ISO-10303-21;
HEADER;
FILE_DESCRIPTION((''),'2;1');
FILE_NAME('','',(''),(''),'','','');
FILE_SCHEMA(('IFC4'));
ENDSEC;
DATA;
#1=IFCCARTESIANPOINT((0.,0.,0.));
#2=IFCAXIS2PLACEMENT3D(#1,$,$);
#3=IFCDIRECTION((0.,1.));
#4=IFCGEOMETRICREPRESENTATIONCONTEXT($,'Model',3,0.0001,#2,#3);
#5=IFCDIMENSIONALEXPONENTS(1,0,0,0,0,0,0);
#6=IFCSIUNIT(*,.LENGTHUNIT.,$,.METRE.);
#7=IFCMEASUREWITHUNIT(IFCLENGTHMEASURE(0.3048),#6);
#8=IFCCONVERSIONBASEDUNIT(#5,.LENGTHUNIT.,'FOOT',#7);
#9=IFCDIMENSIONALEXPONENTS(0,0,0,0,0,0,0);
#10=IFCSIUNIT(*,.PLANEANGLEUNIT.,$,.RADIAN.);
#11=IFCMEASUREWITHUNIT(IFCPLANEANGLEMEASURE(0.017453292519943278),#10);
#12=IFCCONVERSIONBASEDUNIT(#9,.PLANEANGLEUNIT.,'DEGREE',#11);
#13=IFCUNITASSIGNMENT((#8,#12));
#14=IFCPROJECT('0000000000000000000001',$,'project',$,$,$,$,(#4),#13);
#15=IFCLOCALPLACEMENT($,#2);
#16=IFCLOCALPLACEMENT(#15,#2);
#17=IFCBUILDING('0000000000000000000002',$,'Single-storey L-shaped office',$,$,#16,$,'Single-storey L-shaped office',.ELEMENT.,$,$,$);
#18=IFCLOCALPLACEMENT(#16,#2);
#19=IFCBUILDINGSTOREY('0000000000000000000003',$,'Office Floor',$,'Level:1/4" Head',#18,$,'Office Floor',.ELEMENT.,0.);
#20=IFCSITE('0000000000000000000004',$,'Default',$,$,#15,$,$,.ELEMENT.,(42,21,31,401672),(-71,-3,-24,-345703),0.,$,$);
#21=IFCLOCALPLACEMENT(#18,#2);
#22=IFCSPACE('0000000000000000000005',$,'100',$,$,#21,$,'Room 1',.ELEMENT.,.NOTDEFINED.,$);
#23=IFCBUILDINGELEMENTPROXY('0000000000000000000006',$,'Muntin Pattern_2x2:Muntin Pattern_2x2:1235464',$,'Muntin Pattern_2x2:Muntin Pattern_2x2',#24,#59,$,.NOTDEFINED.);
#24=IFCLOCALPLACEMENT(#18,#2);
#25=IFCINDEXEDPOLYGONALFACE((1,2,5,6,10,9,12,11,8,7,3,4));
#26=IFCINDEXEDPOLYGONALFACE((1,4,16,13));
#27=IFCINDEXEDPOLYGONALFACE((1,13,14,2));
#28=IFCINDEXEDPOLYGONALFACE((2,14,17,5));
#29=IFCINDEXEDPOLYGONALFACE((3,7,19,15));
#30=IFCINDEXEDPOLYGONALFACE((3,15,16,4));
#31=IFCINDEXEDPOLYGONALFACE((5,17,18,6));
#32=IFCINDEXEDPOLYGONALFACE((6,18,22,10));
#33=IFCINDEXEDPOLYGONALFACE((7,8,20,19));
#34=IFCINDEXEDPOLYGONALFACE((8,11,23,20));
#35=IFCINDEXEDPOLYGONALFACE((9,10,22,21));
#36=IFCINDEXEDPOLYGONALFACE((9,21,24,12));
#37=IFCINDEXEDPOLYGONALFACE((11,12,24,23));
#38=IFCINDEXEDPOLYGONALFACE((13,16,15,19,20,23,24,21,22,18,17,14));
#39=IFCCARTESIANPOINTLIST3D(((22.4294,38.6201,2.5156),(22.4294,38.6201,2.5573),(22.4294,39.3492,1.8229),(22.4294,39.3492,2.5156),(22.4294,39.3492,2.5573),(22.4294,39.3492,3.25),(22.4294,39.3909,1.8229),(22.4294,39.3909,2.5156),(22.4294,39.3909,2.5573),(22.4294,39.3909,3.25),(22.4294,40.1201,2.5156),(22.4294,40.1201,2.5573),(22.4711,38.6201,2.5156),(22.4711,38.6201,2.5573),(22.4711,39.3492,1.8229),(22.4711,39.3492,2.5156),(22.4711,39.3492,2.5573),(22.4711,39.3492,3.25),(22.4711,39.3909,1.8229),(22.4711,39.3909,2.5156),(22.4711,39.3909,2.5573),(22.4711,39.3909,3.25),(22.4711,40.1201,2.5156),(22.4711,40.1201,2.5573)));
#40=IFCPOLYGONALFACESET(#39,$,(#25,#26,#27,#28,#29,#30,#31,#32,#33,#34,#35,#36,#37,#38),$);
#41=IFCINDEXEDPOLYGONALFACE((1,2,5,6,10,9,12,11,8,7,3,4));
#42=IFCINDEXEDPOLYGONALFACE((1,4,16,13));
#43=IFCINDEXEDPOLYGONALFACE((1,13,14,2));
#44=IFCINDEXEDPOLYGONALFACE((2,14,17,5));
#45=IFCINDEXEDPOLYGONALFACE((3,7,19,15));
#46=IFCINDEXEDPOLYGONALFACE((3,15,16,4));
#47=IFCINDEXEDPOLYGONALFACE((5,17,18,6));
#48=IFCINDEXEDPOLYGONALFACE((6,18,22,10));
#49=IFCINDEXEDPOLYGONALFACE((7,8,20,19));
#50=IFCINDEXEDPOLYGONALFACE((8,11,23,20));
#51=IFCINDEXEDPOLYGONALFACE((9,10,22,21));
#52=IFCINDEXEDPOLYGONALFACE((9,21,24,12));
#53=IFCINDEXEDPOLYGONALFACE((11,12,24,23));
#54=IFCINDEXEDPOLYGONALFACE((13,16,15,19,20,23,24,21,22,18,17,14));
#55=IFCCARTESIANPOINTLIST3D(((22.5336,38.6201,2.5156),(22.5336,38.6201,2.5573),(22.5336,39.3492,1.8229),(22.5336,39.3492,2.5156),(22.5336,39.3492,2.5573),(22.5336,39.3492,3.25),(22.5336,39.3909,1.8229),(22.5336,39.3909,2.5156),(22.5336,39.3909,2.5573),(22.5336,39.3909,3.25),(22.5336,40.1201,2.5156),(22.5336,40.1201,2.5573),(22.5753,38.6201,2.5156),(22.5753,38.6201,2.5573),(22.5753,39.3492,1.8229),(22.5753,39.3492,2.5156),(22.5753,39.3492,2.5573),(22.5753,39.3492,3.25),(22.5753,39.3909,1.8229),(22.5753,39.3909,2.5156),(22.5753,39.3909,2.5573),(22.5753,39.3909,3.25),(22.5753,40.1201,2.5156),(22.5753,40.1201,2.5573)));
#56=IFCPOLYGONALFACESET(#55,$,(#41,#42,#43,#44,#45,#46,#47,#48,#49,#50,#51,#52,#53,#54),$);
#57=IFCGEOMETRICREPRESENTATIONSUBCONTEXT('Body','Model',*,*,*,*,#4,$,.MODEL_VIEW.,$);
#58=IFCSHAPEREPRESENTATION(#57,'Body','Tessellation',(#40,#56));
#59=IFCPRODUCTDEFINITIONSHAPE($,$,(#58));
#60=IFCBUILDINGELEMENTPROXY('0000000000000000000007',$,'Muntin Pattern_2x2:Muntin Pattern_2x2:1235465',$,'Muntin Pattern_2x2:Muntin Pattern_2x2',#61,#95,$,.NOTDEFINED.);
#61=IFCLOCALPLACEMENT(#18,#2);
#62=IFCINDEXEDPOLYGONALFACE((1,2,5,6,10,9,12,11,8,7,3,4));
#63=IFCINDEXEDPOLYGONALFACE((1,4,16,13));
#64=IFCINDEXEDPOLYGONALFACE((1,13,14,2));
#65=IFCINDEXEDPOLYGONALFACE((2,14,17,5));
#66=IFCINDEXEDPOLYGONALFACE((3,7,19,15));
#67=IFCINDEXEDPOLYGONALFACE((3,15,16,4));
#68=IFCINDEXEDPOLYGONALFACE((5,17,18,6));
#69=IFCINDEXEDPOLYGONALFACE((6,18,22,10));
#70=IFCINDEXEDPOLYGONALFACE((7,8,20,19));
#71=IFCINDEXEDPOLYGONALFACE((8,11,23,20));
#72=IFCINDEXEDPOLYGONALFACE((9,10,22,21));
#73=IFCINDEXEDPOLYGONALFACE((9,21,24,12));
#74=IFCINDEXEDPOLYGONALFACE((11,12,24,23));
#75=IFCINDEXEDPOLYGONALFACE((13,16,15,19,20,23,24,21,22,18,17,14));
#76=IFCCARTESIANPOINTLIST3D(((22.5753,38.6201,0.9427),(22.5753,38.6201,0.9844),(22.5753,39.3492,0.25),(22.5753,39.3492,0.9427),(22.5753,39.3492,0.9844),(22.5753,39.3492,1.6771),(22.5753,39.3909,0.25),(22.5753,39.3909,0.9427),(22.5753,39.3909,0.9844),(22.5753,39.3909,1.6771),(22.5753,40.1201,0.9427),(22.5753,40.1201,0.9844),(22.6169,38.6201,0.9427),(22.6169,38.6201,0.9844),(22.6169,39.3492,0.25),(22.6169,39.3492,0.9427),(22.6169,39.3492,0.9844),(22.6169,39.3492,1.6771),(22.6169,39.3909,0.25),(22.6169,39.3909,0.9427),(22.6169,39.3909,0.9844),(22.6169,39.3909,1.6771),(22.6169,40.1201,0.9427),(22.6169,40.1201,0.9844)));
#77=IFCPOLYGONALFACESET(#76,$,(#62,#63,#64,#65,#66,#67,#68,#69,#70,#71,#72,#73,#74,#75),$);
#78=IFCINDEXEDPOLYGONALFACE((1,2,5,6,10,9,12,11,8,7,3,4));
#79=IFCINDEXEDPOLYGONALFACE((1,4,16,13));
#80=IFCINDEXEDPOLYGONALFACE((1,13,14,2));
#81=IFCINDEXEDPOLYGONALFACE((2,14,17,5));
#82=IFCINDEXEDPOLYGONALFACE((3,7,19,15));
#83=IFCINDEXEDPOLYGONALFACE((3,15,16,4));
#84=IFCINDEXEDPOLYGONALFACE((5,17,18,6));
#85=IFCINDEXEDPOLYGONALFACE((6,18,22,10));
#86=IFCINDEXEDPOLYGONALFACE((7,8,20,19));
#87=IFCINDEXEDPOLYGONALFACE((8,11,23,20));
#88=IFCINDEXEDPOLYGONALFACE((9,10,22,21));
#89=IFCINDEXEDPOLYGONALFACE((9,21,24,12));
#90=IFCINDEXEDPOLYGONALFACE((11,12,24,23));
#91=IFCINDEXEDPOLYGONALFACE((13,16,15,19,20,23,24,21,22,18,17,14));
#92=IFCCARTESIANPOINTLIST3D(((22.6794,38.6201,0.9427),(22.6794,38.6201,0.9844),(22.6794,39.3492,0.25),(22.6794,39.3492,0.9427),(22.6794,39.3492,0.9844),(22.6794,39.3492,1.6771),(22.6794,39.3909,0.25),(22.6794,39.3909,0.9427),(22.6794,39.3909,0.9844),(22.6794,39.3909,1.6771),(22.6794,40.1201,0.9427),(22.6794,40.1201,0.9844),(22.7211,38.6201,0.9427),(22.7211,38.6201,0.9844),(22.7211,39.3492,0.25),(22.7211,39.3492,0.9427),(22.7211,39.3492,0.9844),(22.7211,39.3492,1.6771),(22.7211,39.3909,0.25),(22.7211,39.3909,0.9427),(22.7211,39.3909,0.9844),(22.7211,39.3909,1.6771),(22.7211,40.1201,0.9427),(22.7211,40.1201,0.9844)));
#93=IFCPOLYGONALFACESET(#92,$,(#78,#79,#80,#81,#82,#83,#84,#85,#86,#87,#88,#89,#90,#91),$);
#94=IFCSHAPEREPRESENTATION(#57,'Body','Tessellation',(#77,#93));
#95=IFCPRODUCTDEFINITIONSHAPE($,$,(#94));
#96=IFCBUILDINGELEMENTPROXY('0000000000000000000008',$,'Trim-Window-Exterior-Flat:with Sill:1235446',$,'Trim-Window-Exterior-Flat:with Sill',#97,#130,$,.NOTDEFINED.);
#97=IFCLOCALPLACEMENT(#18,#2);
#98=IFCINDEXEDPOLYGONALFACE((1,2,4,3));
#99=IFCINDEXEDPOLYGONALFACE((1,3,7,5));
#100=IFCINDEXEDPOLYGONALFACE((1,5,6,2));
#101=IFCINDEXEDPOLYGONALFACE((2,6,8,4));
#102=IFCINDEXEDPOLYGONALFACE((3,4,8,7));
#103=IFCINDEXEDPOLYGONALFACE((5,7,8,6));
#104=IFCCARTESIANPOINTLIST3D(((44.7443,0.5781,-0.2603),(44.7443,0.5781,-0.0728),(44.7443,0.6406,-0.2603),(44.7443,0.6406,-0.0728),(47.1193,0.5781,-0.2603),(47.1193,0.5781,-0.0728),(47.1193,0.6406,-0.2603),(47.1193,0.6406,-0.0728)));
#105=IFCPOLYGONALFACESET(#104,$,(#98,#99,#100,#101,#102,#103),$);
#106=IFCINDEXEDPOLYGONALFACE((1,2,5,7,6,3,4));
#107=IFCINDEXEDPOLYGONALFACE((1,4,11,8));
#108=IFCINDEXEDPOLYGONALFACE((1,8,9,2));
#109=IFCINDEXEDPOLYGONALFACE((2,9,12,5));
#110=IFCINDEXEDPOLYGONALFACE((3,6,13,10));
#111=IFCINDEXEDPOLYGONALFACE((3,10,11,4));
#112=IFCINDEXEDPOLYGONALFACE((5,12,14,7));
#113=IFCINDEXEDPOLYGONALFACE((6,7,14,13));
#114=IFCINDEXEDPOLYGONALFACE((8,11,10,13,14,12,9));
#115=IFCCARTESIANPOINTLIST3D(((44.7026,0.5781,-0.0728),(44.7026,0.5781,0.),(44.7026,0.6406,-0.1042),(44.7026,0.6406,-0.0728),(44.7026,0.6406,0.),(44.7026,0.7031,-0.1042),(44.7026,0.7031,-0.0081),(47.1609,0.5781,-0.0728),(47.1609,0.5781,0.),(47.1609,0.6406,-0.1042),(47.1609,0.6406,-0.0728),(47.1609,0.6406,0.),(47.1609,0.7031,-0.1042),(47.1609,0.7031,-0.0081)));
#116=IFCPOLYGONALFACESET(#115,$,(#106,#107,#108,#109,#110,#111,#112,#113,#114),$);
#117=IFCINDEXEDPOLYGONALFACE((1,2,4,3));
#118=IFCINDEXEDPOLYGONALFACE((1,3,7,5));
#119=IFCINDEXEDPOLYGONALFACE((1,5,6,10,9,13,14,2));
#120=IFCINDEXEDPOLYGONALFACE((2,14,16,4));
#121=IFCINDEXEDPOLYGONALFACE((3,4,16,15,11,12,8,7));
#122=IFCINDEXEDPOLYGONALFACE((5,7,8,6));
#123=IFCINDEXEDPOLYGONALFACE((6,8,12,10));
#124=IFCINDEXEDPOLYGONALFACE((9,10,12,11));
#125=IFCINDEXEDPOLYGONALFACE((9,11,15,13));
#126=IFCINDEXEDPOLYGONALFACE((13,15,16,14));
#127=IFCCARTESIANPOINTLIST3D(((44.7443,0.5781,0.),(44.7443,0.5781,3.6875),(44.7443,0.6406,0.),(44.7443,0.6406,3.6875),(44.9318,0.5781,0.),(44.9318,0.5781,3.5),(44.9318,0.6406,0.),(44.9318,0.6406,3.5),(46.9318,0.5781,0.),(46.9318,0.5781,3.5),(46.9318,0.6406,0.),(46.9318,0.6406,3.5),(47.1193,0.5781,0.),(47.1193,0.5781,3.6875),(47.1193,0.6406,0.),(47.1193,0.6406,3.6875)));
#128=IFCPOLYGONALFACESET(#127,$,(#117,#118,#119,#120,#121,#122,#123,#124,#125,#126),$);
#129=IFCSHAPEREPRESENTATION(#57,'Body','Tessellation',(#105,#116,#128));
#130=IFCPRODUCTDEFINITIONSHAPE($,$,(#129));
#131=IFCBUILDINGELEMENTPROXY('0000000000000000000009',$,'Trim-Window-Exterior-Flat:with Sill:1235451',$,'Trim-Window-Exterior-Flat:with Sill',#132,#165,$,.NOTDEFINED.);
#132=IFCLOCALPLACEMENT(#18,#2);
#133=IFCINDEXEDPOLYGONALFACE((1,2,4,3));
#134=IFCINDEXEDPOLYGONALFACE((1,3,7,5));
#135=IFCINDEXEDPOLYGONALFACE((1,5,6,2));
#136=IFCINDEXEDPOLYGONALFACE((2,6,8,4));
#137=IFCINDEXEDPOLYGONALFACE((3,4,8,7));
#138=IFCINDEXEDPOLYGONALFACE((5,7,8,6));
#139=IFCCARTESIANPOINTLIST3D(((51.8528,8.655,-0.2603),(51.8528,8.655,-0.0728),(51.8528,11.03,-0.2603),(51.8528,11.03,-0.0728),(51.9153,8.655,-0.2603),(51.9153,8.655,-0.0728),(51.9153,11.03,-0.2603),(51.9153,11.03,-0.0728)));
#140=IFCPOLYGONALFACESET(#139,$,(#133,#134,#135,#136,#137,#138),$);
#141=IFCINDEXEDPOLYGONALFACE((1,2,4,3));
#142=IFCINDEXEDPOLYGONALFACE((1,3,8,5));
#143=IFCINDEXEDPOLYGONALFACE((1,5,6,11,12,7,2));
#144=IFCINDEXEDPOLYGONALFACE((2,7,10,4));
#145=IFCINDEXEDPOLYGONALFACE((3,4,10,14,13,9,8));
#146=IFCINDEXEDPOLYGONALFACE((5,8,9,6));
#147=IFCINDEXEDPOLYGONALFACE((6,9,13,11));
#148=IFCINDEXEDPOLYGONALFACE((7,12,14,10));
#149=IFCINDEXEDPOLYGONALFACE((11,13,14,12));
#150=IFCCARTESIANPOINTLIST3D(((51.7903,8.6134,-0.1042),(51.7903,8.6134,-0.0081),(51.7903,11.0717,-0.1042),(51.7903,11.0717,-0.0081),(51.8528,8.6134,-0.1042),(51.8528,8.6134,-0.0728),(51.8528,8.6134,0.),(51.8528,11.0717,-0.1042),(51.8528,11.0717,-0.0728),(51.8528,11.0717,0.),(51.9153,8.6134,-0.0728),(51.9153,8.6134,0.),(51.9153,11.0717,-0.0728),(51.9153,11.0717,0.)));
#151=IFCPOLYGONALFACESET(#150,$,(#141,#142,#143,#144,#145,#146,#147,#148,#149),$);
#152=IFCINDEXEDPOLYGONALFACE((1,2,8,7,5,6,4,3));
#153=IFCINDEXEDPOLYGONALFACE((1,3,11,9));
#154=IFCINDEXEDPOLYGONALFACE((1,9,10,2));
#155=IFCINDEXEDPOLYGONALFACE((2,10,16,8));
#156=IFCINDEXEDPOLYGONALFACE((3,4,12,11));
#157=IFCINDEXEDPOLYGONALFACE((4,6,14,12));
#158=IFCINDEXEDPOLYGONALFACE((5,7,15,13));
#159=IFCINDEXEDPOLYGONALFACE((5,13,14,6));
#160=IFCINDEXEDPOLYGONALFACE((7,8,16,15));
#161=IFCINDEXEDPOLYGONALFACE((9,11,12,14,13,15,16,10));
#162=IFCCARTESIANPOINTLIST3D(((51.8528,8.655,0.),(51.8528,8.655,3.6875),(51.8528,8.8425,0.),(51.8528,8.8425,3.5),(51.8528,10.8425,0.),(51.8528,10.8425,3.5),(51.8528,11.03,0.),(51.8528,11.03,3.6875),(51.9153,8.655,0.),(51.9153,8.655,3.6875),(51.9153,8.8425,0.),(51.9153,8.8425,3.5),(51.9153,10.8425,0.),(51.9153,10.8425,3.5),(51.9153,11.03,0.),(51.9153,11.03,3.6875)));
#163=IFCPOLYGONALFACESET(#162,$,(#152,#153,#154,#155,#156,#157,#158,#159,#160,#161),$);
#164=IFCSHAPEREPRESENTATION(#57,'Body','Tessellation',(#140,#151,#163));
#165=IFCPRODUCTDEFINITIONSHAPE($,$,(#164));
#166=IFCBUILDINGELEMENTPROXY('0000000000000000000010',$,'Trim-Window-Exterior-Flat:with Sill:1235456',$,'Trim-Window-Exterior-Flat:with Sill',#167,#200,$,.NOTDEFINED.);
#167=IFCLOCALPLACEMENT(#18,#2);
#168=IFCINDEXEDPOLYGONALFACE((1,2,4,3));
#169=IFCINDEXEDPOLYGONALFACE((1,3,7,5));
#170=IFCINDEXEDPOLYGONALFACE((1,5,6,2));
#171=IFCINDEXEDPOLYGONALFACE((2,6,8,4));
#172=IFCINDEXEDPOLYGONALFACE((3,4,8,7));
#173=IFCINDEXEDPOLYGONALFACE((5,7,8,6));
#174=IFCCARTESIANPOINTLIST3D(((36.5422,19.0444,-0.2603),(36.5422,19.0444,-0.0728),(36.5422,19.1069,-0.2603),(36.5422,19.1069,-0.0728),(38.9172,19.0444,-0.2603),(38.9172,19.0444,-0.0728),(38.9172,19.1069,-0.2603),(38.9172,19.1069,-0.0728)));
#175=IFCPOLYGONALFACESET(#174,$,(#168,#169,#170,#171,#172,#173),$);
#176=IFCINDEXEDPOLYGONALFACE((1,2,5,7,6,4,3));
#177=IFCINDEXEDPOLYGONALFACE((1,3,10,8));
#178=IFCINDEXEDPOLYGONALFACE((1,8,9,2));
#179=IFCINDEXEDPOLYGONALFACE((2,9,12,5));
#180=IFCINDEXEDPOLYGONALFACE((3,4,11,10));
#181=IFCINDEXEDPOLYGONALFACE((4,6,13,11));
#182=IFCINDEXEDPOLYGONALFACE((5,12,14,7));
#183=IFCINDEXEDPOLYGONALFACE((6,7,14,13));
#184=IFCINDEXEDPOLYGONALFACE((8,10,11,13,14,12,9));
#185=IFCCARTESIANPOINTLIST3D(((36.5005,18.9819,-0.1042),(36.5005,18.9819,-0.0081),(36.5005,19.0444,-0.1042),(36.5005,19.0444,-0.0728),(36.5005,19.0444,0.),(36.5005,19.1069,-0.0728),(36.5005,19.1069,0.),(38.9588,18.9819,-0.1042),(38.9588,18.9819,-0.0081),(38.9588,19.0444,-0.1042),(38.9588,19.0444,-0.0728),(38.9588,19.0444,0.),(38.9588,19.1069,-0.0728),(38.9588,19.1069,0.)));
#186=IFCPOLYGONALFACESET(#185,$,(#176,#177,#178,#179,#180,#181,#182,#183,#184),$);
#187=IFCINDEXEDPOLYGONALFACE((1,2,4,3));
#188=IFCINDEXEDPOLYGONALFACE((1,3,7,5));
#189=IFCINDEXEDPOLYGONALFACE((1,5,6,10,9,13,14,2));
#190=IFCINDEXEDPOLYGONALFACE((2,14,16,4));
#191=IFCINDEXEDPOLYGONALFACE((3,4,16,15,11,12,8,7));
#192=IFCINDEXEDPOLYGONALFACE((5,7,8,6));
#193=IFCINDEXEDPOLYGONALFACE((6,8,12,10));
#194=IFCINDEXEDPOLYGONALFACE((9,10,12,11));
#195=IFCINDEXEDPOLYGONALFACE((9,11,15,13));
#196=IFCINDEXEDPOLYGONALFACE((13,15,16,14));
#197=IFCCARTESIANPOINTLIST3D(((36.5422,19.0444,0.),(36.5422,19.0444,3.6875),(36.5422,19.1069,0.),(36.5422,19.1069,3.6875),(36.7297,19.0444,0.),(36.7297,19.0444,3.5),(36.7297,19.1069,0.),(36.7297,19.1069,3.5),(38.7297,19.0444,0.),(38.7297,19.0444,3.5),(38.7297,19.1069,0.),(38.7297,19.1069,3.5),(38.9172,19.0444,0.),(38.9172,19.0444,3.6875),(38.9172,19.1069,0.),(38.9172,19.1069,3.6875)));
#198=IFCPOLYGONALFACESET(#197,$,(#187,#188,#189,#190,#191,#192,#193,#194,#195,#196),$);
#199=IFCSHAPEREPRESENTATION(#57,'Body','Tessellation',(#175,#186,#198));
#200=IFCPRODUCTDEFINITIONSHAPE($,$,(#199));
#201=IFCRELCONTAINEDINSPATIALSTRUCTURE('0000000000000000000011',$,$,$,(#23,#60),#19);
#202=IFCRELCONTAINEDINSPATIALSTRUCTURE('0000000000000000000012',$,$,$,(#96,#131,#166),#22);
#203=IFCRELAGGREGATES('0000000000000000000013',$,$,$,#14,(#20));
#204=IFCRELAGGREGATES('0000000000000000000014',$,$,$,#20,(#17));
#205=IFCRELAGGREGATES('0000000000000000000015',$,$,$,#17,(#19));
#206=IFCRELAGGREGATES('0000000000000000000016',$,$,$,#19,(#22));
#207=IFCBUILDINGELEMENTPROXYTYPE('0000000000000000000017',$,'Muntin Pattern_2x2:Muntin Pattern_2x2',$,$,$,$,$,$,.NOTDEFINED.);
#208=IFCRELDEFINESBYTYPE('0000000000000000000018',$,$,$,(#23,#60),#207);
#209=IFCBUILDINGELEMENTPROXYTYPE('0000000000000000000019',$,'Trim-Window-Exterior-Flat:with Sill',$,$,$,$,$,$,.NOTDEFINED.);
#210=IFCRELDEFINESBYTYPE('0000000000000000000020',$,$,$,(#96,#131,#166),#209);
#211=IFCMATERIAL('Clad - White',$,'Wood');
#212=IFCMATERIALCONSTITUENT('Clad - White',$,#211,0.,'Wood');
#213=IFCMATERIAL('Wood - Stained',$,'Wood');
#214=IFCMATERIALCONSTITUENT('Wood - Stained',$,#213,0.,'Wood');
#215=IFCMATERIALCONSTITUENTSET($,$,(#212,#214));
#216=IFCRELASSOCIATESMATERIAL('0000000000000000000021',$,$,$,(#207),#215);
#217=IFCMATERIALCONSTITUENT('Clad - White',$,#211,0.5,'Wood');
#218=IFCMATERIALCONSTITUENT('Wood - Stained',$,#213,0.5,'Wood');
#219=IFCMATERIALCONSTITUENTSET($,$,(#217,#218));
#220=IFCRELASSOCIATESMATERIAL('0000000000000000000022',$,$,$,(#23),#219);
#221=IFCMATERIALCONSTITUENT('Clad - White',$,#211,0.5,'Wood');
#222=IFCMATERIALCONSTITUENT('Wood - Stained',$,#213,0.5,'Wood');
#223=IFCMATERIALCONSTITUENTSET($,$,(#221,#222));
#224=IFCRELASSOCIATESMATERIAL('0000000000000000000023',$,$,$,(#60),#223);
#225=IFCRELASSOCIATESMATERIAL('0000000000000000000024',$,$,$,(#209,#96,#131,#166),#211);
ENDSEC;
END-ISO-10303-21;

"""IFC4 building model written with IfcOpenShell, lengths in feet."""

from ifc_helpers import new_model, entity, si_unit, converted_unit, direction, frame, origin, place, context, subcontext, project, spatial, indexed_curve, outline, extrude, source, transform, mapped, material, constituent, constituent_set, type_object, type_shapes, element, save


model = new_model("IFC4")

# Units and contexts
model_context = context("Model", 3, precision=0.0001, world=origin(), true_north=direction((0.0, 1.0)))
body_context = subcontext(model_context, "Body", "Model", "MODEL_VIEW")
ifc_project = project(units=[converted_unit("LENGTHUNIT", "FOOT", entity("IfcLengthMeasure", 0.3048), si_unit("LENGTHUNIT", "METRE"), dimensions=[1, 0, 0, 0, 0, 0, 0]), converted_unit("PLANEANGLEUNIT", "DEGREE", entity("IfcPlaneAngleMeasure", 0.017453292519943278), si_unit("PLANEANGLEUNIT", "RADIAN"), dimensions=[0, 0, 0, 0, 0, 0, 0])], contexts=[model_context])

# Site, building, storey
site_placement = place(None, origin())
site = spatial("IfcSite", under=ifc_project, at=site_placement, Name="Default", CompositionType="ELEMENT", RefLatitude=(42, 21, 31, 401672), RefLongitude=(-71, -3, -24, -345703), RefElevation=0.0)
building_placement = place(site_placement, origin())
building = spatial("IfcBuilding", under=site, at=building_placement, Name="Single-storey L-shaped office", LongName="Single-storey L-shaped office", CompositionType="ELEMENT")
storey_placement = place(building_placement, origin())
storey = spatial("IfcBuildingStorey", under=building, at=storey_placement, Name="Office Floor", ObjectType="Level:1/4\" Head", LongName="Office Floor", CompositionType="ELEMENT", Elevation=0.0)

# Shared definitions
ifc_material_1 = material(Name="Wood - Stained", Category="Wood")

# Building element proxies
ifc_material_2 = material(Name="Clad - White", Category="Wood")
ifc_constituent_1 = constituent(ifc_material_2, Name="Clad - White", Category="Wood", fraction=0.0)
ifc_constituent_2 = constituent(ifc_material_1, Name="Wood - Stained", Category="Wood", fraction=0.0)
ifc_constituent_set_1 = constituent_set(constituents=[ifc_constituent_1, ifc_constituent_2])
building_element_proxy_type_1 = type_object("IfcBuildingElementProxyType", Name="Muntin Pattern_2x2:Muntin Pattern_2x2", PredefinedType="NOTDEFINED", material=ifc_constituent_set_1)
shared_shape_1 = source(origin(), body_context, "Body", "SweptSolid", [
    extrude(outline(indexed_curve([(0.0208, -0.0208), (0.7135, -0.0208), (0.7135, 0.0208), (0.0208, 0.0208), (0.0208, 0.75), (-0.0208, 0.75), (-0.0208, 0.0208), (-0.7135, 0.0208), (-0.7135, -0.0208), (-0.0208, -0.0208), (-0.0208, -0.75), (0.0208, -0.75), (0.0208, -0.0208)], self_intersect=False)), frame((0.0, 0.0312, 0.7135), z_axis=(0.0, 1.0, 0.0), x_axis=(0.0, 0.0, 1.0)), (0.0, 0.0, 1.0), 0.0417),
    extrude(outline(indexed_curve([(0.0208, -0.0208), (0.7135, -0.0208), (0.7135, 0.0208), (0.0208, 0.0208), (0.0208, 0.75), (-0.0208, 0.75), (-0.0208, 0.0208), (-0.7135, 0.0208), (-0.7135, -0.0208), (-0.0208, -0.0208), (-0.0208, -0.75), (0.0208, -0.75), (0.0208, -0.0208)], self_intersect=False)), frame((0.0, -0.0729, 0.7135), z_axis=(0.0, 1.0, 0.0), x_axis=(0.0, 0.0, 1.0)), (0.0, 0.0, 1.0), 0.0417),
])
type_shapes(building_element_proxy_type_1, [shared_shape_1])
ifc_constituent_3 = constituent(ifc_material_2, Name="Clad - White", Category="Wood", fraction=0.5)
ifc_constituent_4 = constituent(ifc_material_1, Name="Wood - Stained", Category="Wood", fraction=0.5)
ifc_constituent_set_2 = constituent_set(constituents=[ifc_constituent_3, ifc_constituent_4])
proxy_1_placement = place(storey_placement, frame((22.5023, 39.3701, 1.8229), z_axis=(0.0, 0.0, 1.0), x_axis=(0.0, 1.0, 0.0)))
element("IfcBuildingElementProxy", 1, at=proxy_1_placement, inside=storey, type_object=building_element_proxy_type_1, material=ifc_constituent_set_2, Name="Muntin Pattern_2x2:Muntin Pattern_2x2:1235464", ObjectType="Muntin Pattern_2x2:Muntin Pattern_2x2", PredefinedType="NOTDEFINED", context=body_context, shape_type="MappedRepresentation", body=[
    mapped(shared_shape_1, transform((0.0, 0.0, 0.0), scale=1.0)),
])
ifc_constituent_5 = constituent(ifc_material_2, Name="Clad - White", Category="Wood", fraction=0.5)
ifc_constituent_6 = constituent(ifc_material_1, Name="Wood - Stained", Category="Wood", fraction=0.5)
ifc_constituent_set_3 = constituent_set(constituents=[ifc_constituent_5, ifc_constituent_6])
proxy_2_placement = place(storey_placement, frame((22.6482, 39.3701, 0.25), z_axis=(0.0, 0.0, 1.0), x_axis=(0.0, 1.0, 0.0)))
element("IfcBuildingElementProxy", 2, at=proxy_2_placement, inside=storey, type_object=building_element_proxy_type_1, material=ifc_constituent_set_3, Name="Muntin Pattern_2x2:Muntin Pattern_2x2:1235465", ObjectType="Muntin Pattern_2x2:Muntin Pattern_2x2", PredefinedType="NOTDEFINED", context=body_context, shape_type="MappedRepresentation", body=[
    mapped(shared_shape_1, transform((0.0, 0.0, 0.0), scale=1.0)),
])

# Shared definitions
space_1_placement = place(storey_placement, origin())
space_1 = spatial("IfcSpace", under=storey, at=space_1_placement, Name="100", LongName="Room 1", CompositionType="ELEMENT", PredefinedType="NOTDEFINED")

# Building element proxies
building_element_proxy_type_2 = type_object("IfcBuildingElementProxyType", Name="Trim-Window-Exterior-Flat:with Sill", PredefinedType="NOTDEFINED", material=ifc_material_2)
shared_shape_2 = source(origin(), body_context, "Body", "SweptSolid", [
    extrude(outline(indexed_curve([(-1.1875, -0.0938), (1.1875, -0.0938), (1.1875, 0.0938), (-1.1875, 0.0938), (-1.1875, -0.0938)], self_intersect=False)), frame((0.0, -3.6665, 0.0), z_axis=(0.0, 0.0, 1.0), x_axis=(-1.0, 0.0, 0.0)), (0.0, 0.0, 1.0), 0.0625),
    extrude(outline(indexed_curve([(-0.0625, -0.0525), (0.0, -0.0525), (0.0, -0.0211), (0.0625, -0.0211), (0.0625, 0.0517), (0.0, 0.0517), (-0.0625, 0.0436), (-0.0625, -0.0525)], self_intersect=False)), frame((-1.2292, -3.5517, 0.0625), z_axis=(1.0, 0.0, 0.0), x_axis=(0.0, 0.0, -1.0)), (0.0, 0.0, 1.0), 2.4583),
    extrude(outline(indexed_curve([(-1.8906, -1.1875), (1.7969, -1.1875), (1.7969, -1.0), (-1.7031, -1.0), (-1.7031, 1.0), (1.7969, 1.0), (1.7969, 1.1875), (-1.8906, 1.1875), (-1.8906, -1.1875)], self_intersect=False)), frame((0.0, -1.7031, 0.0), z_axis=(0.0, 0.0, 1.0), x_axis=(0.0, -1.0, 0.0)), (0.0, 0.0, 1.0), 0.0625),
])
type_shapes(building_element_proxy_type_2, [shared_shape_2])
for number, where, z_axis, x_axis, name in (
    (3, (45.9318, 0.5781, 3.5), (0.0, 1.0, 0.0), (-1.0, 0.0, 0.0), "Trim-Window-Exterior-Flat:with Sill:1235446"),
    (4, (51.9153, 9.8425, 3.5), (-1.0, 0.0, 0.0), (0.0, -1.0, 0.0), "Trim-Window-Exterior-Flat:with Sill:1235451"),
    (5, (37.7297, 19.1069, 3.5), (0.0, -1.0, 0.0), (1.0, 0.0, 0.0), "Trim-Window-Exterior-Flat:with Sill:1235456"),
):
    element("IfcBuildingElementProxy", number, at=place(space_1_placement, frame(where, z_axis=z_axis, x_axis=x_axis)), inside=space_1, type_object=building_element_proxy_type_2, material=ifc_material_2, Name=name, ObjectType="Trim-Window-Exterior-Flat:with Sill", PredefinedType="NOTDEFINED", context=body_context, shape_type="MappedRepresentation", body=[
        mapped(shared_shape_2, transform((0.0, 0.0, 0.0), scale=1.0)),
    ])

save(model, "model.ifc")
